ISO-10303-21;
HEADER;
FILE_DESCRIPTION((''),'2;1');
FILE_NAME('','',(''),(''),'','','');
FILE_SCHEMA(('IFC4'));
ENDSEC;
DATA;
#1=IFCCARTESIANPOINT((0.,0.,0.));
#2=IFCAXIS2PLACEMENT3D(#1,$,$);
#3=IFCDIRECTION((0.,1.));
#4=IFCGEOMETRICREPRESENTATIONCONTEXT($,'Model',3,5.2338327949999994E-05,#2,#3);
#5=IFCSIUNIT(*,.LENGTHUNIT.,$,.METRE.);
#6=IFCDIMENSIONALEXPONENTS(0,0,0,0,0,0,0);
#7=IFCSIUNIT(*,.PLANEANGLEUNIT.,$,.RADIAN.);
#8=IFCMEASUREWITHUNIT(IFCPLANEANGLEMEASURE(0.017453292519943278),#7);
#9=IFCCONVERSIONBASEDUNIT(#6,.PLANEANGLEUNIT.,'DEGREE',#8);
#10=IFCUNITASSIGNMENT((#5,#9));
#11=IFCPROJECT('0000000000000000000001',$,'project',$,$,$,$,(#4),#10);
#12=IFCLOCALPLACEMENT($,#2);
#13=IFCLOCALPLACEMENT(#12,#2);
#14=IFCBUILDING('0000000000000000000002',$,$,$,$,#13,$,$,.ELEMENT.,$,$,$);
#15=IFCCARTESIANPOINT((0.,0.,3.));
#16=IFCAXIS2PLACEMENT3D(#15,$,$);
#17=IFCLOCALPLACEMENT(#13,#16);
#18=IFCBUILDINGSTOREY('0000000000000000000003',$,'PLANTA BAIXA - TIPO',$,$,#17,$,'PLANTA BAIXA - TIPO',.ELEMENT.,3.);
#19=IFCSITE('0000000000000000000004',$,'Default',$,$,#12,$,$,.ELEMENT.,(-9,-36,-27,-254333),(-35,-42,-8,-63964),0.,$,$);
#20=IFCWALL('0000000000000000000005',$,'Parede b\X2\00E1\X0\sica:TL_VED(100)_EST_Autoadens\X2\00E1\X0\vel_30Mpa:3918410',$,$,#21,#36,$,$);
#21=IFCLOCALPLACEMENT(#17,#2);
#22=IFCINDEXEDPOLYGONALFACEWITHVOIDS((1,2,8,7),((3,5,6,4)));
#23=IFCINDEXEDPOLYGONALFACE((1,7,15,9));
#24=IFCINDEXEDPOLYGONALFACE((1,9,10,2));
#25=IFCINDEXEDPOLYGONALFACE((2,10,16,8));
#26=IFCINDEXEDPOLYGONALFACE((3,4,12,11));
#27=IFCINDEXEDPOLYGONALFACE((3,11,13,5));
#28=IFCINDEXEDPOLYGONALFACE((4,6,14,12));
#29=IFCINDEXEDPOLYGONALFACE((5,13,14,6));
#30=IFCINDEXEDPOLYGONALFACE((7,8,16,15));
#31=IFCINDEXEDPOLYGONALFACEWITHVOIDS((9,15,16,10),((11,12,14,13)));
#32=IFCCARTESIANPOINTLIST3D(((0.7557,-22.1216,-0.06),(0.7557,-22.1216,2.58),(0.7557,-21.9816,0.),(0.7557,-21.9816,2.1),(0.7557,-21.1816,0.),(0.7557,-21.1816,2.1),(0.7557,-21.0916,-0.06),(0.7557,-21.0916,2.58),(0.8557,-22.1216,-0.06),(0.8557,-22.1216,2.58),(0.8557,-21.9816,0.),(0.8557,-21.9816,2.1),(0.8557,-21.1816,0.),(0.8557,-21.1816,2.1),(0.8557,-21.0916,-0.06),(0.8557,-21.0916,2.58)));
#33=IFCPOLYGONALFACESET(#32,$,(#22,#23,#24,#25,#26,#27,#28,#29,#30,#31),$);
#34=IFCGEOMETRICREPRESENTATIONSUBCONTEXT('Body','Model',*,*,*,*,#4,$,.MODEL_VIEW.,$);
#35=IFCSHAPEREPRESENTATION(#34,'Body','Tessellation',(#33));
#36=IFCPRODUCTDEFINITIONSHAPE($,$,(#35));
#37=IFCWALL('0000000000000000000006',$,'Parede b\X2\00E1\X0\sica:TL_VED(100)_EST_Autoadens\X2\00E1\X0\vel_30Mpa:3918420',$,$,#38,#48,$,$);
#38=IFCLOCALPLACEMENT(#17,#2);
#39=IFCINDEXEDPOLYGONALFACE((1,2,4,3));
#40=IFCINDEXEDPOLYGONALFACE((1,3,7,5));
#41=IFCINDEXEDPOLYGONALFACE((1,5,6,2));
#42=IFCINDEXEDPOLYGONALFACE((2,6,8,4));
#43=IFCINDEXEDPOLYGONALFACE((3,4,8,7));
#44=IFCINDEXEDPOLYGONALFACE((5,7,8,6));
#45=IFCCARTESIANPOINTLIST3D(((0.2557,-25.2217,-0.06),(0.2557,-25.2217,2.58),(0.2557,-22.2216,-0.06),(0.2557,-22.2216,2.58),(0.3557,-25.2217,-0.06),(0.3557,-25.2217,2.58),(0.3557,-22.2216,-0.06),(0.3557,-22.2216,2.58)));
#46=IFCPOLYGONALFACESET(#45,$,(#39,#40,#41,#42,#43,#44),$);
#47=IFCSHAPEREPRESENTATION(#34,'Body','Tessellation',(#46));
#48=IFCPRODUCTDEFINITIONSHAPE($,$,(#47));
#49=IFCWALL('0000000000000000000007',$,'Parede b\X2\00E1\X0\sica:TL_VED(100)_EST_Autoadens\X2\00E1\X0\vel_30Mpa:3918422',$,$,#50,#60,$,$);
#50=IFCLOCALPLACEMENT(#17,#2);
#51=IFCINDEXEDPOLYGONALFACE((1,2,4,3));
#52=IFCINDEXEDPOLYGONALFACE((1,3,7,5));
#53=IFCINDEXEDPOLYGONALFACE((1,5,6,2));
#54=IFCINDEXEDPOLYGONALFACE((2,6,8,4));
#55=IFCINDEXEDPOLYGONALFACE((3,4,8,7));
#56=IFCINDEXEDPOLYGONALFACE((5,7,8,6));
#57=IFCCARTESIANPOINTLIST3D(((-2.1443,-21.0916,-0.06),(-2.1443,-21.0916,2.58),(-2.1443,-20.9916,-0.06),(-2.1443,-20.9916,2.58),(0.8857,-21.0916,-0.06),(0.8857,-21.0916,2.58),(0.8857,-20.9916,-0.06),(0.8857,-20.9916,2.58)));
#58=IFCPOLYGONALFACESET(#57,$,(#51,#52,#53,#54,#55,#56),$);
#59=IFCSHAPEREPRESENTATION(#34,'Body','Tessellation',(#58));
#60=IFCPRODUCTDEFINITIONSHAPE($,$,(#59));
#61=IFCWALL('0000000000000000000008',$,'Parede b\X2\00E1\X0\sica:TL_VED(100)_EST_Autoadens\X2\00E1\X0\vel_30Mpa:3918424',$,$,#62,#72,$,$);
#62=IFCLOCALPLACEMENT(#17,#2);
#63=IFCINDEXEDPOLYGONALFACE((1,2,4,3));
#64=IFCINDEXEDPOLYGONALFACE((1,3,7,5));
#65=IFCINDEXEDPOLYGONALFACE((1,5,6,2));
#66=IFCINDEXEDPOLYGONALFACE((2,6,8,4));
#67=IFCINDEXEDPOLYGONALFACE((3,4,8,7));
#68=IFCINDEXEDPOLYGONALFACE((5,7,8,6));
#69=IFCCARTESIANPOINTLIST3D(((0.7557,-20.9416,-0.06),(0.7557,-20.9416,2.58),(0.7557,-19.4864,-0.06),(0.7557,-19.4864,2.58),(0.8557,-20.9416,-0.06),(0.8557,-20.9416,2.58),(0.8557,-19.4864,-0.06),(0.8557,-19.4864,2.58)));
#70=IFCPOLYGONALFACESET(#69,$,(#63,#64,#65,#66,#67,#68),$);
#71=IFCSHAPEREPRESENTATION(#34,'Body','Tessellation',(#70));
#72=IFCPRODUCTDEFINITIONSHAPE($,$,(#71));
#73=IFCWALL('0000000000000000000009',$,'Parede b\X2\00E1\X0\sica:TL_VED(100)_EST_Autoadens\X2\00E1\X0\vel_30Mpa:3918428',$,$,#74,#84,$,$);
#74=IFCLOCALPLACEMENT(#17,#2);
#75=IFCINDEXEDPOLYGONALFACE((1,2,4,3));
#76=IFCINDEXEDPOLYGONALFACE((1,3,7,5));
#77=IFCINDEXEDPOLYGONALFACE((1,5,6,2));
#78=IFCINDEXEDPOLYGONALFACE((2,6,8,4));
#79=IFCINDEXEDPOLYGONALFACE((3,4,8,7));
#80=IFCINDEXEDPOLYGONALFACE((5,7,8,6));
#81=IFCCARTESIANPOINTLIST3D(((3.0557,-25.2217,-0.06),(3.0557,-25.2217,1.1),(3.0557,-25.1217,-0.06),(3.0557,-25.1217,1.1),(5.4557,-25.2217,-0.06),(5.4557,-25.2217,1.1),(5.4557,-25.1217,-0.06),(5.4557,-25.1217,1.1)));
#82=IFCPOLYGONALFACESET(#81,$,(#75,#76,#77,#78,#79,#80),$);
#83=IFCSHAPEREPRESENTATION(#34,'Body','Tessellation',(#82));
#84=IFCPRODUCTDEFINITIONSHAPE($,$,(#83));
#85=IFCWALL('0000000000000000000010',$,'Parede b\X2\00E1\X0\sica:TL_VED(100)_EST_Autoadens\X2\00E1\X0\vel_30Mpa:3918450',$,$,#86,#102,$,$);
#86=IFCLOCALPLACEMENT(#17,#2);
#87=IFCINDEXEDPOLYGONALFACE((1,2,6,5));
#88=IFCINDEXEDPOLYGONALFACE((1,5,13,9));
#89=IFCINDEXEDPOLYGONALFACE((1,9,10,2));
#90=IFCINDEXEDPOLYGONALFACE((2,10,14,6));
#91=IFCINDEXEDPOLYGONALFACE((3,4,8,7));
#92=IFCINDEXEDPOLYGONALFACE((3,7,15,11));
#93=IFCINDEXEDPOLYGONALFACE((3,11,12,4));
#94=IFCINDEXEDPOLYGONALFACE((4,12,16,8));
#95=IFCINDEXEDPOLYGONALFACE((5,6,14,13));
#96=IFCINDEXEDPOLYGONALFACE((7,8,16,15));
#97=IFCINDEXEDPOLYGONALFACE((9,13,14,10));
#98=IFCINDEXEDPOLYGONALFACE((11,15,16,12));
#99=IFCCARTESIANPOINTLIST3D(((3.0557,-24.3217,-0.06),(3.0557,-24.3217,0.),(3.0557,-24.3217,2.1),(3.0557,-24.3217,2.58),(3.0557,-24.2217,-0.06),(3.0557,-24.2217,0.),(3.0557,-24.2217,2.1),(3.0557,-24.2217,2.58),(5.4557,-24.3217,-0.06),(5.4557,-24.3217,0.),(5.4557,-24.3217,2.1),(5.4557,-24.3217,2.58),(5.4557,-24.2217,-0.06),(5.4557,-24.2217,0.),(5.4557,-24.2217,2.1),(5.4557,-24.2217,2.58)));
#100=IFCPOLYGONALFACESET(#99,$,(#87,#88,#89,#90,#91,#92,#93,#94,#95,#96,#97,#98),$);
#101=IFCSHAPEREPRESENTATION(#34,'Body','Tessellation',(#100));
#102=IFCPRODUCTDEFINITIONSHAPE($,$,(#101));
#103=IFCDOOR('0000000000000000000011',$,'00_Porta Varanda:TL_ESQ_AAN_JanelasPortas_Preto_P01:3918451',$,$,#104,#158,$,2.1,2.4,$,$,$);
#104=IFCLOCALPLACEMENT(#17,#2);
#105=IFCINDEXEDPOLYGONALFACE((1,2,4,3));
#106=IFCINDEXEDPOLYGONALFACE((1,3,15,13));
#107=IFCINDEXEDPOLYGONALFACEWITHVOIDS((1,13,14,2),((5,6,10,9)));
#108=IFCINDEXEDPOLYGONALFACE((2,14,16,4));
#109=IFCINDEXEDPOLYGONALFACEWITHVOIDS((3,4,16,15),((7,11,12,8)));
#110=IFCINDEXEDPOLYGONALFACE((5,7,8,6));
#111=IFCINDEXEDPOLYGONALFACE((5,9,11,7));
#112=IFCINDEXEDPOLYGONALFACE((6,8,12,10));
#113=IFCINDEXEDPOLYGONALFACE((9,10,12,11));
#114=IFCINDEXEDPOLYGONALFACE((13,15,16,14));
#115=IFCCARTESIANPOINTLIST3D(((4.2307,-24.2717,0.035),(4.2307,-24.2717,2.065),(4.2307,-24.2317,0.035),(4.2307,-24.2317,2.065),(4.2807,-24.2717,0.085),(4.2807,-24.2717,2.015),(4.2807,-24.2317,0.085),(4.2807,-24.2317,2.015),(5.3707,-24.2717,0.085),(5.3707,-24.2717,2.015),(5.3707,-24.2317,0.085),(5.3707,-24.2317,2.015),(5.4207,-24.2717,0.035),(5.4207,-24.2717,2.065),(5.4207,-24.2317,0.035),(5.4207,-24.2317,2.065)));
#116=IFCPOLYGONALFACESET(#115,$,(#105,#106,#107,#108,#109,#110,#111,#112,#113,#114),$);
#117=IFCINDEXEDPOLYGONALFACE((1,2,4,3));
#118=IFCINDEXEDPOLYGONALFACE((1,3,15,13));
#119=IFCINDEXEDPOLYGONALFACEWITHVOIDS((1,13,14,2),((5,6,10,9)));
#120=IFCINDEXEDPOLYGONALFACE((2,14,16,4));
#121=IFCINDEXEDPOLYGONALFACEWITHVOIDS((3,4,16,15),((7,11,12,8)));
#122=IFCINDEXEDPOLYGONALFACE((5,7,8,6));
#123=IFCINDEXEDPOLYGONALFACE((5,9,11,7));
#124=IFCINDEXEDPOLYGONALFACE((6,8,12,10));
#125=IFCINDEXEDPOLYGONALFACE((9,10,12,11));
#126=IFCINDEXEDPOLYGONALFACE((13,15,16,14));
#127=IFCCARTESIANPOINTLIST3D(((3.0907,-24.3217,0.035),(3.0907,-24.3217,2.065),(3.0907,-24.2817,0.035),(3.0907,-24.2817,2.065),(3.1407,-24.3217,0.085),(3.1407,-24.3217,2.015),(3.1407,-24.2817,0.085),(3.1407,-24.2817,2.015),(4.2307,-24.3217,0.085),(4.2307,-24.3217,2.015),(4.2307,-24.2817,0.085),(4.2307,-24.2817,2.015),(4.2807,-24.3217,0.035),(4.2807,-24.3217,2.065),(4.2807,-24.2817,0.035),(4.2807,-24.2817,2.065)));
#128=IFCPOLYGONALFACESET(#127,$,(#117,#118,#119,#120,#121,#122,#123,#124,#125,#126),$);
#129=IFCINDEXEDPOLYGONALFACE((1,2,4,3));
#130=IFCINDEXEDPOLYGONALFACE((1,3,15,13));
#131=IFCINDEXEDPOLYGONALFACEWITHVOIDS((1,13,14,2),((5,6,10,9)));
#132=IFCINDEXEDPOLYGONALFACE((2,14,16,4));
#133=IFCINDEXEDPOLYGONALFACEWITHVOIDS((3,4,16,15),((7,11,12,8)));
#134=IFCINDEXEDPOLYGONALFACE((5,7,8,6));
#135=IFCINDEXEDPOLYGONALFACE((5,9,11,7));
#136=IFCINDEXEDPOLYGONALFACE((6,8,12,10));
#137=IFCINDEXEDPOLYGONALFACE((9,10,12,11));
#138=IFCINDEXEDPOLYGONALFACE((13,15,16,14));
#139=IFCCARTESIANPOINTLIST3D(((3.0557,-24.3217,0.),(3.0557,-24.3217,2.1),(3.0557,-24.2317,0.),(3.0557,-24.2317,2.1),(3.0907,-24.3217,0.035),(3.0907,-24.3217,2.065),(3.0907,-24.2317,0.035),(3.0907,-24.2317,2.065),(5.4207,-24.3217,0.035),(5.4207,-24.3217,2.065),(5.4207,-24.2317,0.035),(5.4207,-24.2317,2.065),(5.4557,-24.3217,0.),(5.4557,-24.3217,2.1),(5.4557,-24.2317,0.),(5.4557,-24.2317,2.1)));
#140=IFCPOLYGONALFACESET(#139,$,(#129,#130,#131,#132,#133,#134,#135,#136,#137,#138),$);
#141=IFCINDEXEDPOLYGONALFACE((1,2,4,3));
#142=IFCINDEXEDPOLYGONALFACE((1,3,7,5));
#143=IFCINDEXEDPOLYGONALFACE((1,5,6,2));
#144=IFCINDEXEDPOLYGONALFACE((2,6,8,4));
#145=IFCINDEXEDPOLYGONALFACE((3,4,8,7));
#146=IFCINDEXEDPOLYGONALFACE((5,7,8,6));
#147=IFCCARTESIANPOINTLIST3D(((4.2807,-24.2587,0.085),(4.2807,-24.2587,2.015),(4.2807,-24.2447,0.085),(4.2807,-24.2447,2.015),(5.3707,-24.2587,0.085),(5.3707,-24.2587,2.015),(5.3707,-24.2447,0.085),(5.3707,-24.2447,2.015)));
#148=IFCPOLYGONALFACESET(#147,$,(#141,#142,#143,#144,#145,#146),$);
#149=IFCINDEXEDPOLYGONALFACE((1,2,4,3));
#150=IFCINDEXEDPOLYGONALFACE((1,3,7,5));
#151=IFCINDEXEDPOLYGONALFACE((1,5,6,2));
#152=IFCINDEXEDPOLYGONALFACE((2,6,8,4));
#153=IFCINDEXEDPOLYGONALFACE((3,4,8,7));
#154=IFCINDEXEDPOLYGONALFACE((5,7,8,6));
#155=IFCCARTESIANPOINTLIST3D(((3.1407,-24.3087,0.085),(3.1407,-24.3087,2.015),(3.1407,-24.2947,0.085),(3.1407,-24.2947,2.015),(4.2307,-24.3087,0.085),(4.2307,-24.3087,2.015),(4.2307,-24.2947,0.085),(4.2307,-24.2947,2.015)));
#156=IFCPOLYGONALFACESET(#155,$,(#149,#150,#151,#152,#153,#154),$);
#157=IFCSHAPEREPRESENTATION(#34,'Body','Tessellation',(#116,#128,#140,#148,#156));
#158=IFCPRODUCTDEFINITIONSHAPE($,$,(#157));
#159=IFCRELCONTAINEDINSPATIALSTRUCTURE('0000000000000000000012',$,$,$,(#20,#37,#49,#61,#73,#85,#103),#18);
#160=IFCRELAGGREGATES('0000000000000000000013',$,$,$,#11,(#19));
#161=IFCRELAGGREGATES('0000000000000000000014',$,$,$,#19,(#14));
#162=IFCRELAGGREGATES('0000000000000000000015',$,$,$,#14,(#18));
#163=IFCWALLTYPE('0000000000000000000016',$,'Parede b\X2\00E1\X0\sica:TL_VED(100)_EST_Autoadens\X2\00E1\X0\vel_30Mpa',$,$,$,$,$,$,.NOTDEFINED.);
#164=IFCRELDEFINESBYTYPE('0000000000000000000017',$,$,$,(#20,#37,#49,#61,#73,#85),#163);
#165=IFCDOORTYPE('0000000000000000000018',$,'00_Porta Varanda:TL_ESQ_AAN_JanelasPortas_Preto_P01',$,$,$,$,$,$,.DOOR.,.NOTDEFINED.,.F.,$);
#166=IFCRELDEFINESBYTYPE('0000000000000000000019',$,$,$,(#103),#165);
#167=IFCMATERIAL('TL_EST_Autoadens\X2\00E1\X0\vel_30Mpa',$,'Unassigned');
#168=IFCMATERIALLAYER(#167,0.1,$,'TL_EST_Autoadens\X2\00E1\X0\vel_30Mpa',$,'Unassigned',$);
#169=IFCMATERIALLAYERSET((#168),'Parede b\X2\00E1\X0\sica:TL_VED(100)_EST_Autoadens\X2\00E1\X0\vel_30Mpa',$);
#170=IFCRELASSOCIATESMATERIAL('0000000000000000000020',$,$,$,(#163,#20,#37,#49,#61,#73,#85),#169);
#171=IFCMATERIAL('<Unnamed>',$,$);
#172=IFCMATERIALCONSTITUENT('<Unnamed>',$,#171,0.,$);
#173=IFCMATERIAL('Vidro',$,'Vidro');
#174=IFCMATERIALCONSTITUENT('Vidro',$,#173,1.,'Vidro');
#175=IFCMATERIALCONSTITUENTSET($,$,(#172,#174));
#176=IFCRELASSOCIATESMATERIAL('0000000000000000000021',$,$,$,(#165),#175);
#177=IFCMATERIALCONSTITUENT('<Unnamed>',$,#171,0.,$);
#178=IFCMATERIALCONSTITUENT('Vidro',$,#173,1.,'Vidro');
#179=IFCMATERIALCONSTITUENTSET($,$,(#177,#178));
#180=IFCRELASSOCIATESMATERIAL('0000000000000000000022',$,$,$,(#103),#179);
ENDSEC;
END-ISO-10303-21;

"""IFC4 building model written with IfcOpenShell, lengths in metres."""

from ifc_helpers import new_model, entity, si_unit, converted_unit, direction, frame, frame_2d, origin, place, context, subcontext, project, spatial, polyline, rectangle, outline, extrude, source, transform, mapped, material, layer, layer_set, layer_usage, constituent, constituent_set, type_object, type_shapes, element, fill, save


model = new_model("IFC4")

# Units and contexts
model_context = context("Model", 3, precision=5.2338327949999994e-05, world=origin(), true_north=direction((0.0, 1.0)))
body_context = subcontext(model_context, "Body", "Model", "MODEL_VIEW")
ifc_project = project(units=[si_unit("LENGTHUNIT", "METRE"), converted_unit("PLANEANGLEUNIT", "DEGREE", entity("IfcPlaneAngleMeasure", 0.017453292519943278), si_unit("PLANEANGLEUNIT", "RADIAN"), dimensions=[0, 0, 0, 0, 0, 0, 0])], contexts=[model_context])

# Site, building, storey
site_placement = place(None, frame((0.0, 0.0, 0.0)))
site = spatial("IfcSite", under=ifc_project, at=site_placement, Name="Default", CompositionType="ELEMENT", RefLatitude=(-9, -36, -27, -254333), RefLongitude=(-35, -42, -8, -63964), RefElevation=0.0)
building_placement = place(site_placement, origin())
building = spatial("IfcBuilding", under=site, at=building_placement, CompositionType="ELEMENT")
storey_placement = place(building_placement, frame((0.0, 0.0, 3.0)))
storey = spatial("IfcBuildingStorey", under=building, at=storey_placement, Name="PLANTA BAIXA - TIPO", LongName="PLANTA BAIXA - TIPO", CompositionType="ELEMENT", Elevation=3.0)

# Wall, opening
ifc_material_1 = material(Name="TL_EST_Autoadensável_30Mpa", Category="Unassigned")
ifc_layer_1 = layer(ifc_material_1, 0.1, Name="TL_EST_Autoadensável_30Mpa", Category="Unassigned")
ifc_layer_set_1 = layer_set([ifc_layer_1], Name="Parede básica:TL_VED(100)_EST_Autoadensável_30Mpa")
ifc_layer_usage_1 = layer_usage(ifc_layer_set_1, "AXIS2", "NEGATIVE", 0.05)
wall_type_1 = type_object("IfcWallType", Name="Parede básica:TL_VED(100)_EST_Autoadensável_30Mpa", PredefinedType="NOTDEFINED", material=ifc_layer_set_1)
wall_1_placement = place(storey_placement, frame((0.8057, -22.1216, -0.06), z_axis=(0.0, 0.0, 1.0), x_axis=(0.0, 1.0, 0.0)))
wall_1 = element("IfcWall", 1, at=wall_1_placement, inside=storey, type_object=wall_type_1, material=ifc_layer_usage_1, Name="Parede básica:TL_VED(100)_EST_Autoadensável_30Mpa:3918410", context=body_context, shape_type="SweptSolid", body=[
    extrude(rectangle(XDim=1.03, YDim=0.1, at=frame_2d((0.515, 0.0), x_axis=(-1.0, 0.0))), origin(), (0.0, 0.0, 1.0), 2.64),
])
opening_1_placement = place(wall_1_placement, frame((0.14, -0.05, 0.06)))
element("IfcOpeningElement", 2, at=opening_1_placement, cuts=wall_1, PredefinedType="OPENING", context=body_context, shape_type="SweptSolid", body=[
    extrude(rectangle(XDim=2.1, YDim=0.8, at=frame_2d((1.05, 0.4), x_axis=(1.0, 0.0))), frame((0.0, 0.0, 0.0), z_axis=(0.0, 1.0, 0.0), x_axis=(0.0, 0.0, 1.0)), (0.0, 0.0, 1.0), 0.1),
])

# Walls
ifc_layer_usage_2 = layer_usage(ifc_layer_set_1, "AXIS2", "POSITIVE", -0.05)
wall_2_placement = place(storey_placement, frame((0.3057, -25.2217, -0.06), z_axis=(0.0, 0.0, 1.0), x_axis=(0.0, 1.0, 0.0)))
element("IfcWall", 3, at=wall_2_placement, inside=storey, type_object=wall_type_1, material=ifc_layer_usage_2, Name="Parede básica:TL_VED(100)_EST_Autoadensável_30Mpa:3918420", context=body_context, shape_type="SweptSolid", body=[
    extrude(rectangle(XDim=3.0001, YDim=0.1, at=frame_2d((1.5001, 0.0), x_axis=(-1.0, 0.0))), origin(), (0.0, 0.0, 1.0), 2.64),
])
ifc_layer_usage_3 = layer_usage(ifc_layer_set_1, "AXIS2", "POSITIVE", -0.05)
wall_3_placement = place(storey_placement, frame((0.8857, -21.0416, -0.06), z_axis=(0.0, 0.0, 1.0), x_axis=(-1.0, 0.0, 0.0)))
element("IfcWall", 4, at=wall_3_placement, inside=storey, type_object=wall_type_1, material=ifc_layer_usage_3, Name="Parede básica:TL_VED(100)_EST_Autoadensável_30Mpa:3918422", context=body_context, shape_type="SweptSolid", body=[
    extrude(rectangle(XDim=3.03, YDim=0.1, at=frame_2d((1.515, 0.0), x_axis=(-1.0, 0.0))), origin(), (0.0, 0.0, 1.0), 2.64),
])
ifc_layer_usage_4 = layer_usage(ifc_layer_set_1, "AXIS2", "NEGATIVE", 0.05)
wall_4_placement = place(storey_placement, frame((0.8057, -19.4864, -0.06), z_axis=(0.0, 0.0, 1.0), x_axis=(0.0, -1.0, 0.0)))
element("IfcWall", 5, at=wall_4_placement, inside=storey, type_object=wall_type_1, material=ifc_layer_usage_4, Name="Parede básica:TL_VED(100)_EST_Autoadensável_30Mpa:3918424", context=body_context, shape_type="SweptSolid", body=[
    extrude(rectangle(XDim=1.4552, YDim=0.1, at=frame_2d((0.7276, 0.0), x_axis=(-1.0, 0.0))), origin(), (0.0, 0.0, 1.0), 2.64),
])

# Wall
ifc_layer_usage_5 = layer_usage(ifc_layer_set_1, "AXIS2", "POSITIVE", -0.05)
wall_5_placement = place(storey_placement, frame((3.0557, -25.1717, -0.06)))
element("IfcWall", 6, at=wall_5_placement, inside=storey, type_object=wall_type_1, material=ifc_layer_usage_5, Name="Parede básica:TL_VED(100)_EST_Autoadensável_30Mpa:3918428", context=body_context, shape_type="SweptSolid", body=[
    extrude(rectangle(XDim=2.4, YDim=0.1, at=frame_2d((1.2, 0.0), x_axis=(-1.0, 0.0))), origin(), (0.0, 0.0, 1.0), 1.16),
])

# Wall, opening, door
ifc_layer_usage_6 = layer_usage(ifc_layer_set_1, "AXIS2", "POSITIVE", -0.05)
wall_6_placement = place(storey_placement, frame((3.0557, -24.2717, -0.06)))
wall_6 = element("IfcWall", 7, at=wall_6_placement, inside=storey, type_object=wall_type_1, material=ifc_layer_usage_6, Name="Parede básica:TL_VED(100)_EST_Autoadensável_30Mpa:3918450", context=body_context, shape_type="SweptSolid", body=[
    extrude(rectangle(XDim=2.4, YDim=0.1, at=frame_2d((1.2, 0.0), x_axis=(-1.0, 0.0))), origin(), (0.0, 0.0, 1.0), 2.64),
])
opening_2_placement = place(wall_6_placement, frame((0.0, -0.05, 0.06)))
opening_2 = element("IfcOpeningElement", 8, at=opening_2_placement, cuts=wall_6, PredefinedType="OPENING", context=body_context, shape_type="SweptSolid", body=[
    extrude(rectangle(XDim=2.1, YDim=2.4, at=frame_2d((1.05, 1.2), x_axis=(1.0, 0.0))), frame((0.0, 0.0, 0.0), z_axis=(0.0, 1.0, 0.0), x_axis=(0.0, 0.0, 1.0)), (0.0, 0.0, 1.0), 0.1),
])
ifc_material_2 = material(Name="<Unnamed>")
ifc_constituent_1 = constituent(ifc_material_2, Name="<Unnamed>", fraction=0.0)
ifc_material_3 = material(Name="Vidro", Category="Vidro")
ifc_constituent_2 = constituent(ifc_material_3, Name="Vidro", Category="Vidro", fraction=1.0)
ifc_constituent_set_1 = constituent_set(constituents=[ifc_constituent_1, ifc_constituent_2])
ifc_constituent_3 = constituent(ifc_material_2, Name="<Unnamed>", fraction=0.0)
ifc_constituent_4 = constituent(ifc_material_3, Name="Vidro", Category="Vidro", fraction=1.0)
ifc_constituent_set_2 = constituent_set(constituents=[ifc_constituent_3, ifc_constituent_4])
door_type = type_object("IfcDoorType", Name="00_Porta Varanda:TL_ESQ_AAN_JanelasPortas_Preto_P01", OperationType="NOTDEFINED", ParameterTakesPrecedence=False, PredefinedType="DOOR", material=ifc_constituent_set_2)
shared_shape_1 = source(origin(), body_context, "Body", "SweptSolid", [
    extrude(outline(polyline([(-1.015, -0.595), (1.015, -0.595), (1.015, 0.595), (-1.015, 0.595), (-1.015, -0.595)]), holes=[polyline([(0.965, -0.545), (-0.965, -0.545), (-0.965, 0.545), (0.965, 0.545), (0.965, -0.545)])]), frame((1.77, 0.05, 1.05), z_axis=(0.0, 1.0, 0.0), x_axis=(0.0, 0.0, 1.0)), (0.0, 0.0, 1.0), 0.04),
    extrude(outline(polyline([(-1.015, -0.595), (1.015, -0.595), (1.015, 0.595), (-1.015, 0.595), (-1.015, -0.595)]), holes=[polyline([(0.965, -0.545), (-0.965, -0.545), (-0.965, 0.545), (0.965, 0.545), (0.965, -0.545)])]), frame((0.63, 0.0, 1.05), z_axis=(0.0, 1.0, 0.0), x_axis=(0.0, 0.0, -1.0)), (0.0, 0.0, 1.0), 0.04),
    extrude(outline(polyline([(-1.05, -1.2), (1.05, -1.2), (1.05, 1.2), (-1.05, 1.2), (-1.05, -1.2)]), holes=[polyline([(1.015, -1.165), (-1.015, -1.165), (-1.015, 1.165), (1.015, 1.165), (1.015, -1.165)])]), frame((1.2, 0.0, 1.05), z_axis=(0.0, 1.0, 0.0), x_axis=(0.0, 0.0, -1.0)), (0.0, 0.0, 1.0), 0.09),
    extrude(rectangle(XDim=0.014, YDim=1.09, at=frame_2d((0.0, 0.0), x_axis=(1.0, 0.0))), frame((1.77, 0.07, 0.085), z_axis=(0.0, 0.0, 1.0), x_axis=(0.0, -1.0, 0.0)), (0.0, 0.0, 1.0), 1.93),
    extrude(rectangle(XDim=0.014, YDim=1.09, at=frame_2d((0.0, 0.0), x_axis=(1.0, 0.0))), frame((0.63, 0.02, 0.085), z_axis=(0.0, 0.0, 1.0), x_axis=(0.0, -1.0, 0.0)), (0.0, 0.0, 1.0), 1.93),
])
type_shapes(door_type, [shared_shape_1])
door_placement = place(opening_2_placement, origin())
door = element("IfcDoor", 9, at=door_placement, inside=storey, type_object=door_type, material=ifc_constituent_set_1, Name="00_Porta Varanda:TL_ESQ_AAN_JanelasPortas_Preto_P01:3918451", OverallHeight=2.1, OverallWidth=2.4, context=body_context, shape_type="MappedRepresentation", body=[
    mapped(shared_shape_1, transform((0.0, 0.0, 0.0), scale=1.0)),
])
fill(opening_2, door)

save(model, "model.ifc")
